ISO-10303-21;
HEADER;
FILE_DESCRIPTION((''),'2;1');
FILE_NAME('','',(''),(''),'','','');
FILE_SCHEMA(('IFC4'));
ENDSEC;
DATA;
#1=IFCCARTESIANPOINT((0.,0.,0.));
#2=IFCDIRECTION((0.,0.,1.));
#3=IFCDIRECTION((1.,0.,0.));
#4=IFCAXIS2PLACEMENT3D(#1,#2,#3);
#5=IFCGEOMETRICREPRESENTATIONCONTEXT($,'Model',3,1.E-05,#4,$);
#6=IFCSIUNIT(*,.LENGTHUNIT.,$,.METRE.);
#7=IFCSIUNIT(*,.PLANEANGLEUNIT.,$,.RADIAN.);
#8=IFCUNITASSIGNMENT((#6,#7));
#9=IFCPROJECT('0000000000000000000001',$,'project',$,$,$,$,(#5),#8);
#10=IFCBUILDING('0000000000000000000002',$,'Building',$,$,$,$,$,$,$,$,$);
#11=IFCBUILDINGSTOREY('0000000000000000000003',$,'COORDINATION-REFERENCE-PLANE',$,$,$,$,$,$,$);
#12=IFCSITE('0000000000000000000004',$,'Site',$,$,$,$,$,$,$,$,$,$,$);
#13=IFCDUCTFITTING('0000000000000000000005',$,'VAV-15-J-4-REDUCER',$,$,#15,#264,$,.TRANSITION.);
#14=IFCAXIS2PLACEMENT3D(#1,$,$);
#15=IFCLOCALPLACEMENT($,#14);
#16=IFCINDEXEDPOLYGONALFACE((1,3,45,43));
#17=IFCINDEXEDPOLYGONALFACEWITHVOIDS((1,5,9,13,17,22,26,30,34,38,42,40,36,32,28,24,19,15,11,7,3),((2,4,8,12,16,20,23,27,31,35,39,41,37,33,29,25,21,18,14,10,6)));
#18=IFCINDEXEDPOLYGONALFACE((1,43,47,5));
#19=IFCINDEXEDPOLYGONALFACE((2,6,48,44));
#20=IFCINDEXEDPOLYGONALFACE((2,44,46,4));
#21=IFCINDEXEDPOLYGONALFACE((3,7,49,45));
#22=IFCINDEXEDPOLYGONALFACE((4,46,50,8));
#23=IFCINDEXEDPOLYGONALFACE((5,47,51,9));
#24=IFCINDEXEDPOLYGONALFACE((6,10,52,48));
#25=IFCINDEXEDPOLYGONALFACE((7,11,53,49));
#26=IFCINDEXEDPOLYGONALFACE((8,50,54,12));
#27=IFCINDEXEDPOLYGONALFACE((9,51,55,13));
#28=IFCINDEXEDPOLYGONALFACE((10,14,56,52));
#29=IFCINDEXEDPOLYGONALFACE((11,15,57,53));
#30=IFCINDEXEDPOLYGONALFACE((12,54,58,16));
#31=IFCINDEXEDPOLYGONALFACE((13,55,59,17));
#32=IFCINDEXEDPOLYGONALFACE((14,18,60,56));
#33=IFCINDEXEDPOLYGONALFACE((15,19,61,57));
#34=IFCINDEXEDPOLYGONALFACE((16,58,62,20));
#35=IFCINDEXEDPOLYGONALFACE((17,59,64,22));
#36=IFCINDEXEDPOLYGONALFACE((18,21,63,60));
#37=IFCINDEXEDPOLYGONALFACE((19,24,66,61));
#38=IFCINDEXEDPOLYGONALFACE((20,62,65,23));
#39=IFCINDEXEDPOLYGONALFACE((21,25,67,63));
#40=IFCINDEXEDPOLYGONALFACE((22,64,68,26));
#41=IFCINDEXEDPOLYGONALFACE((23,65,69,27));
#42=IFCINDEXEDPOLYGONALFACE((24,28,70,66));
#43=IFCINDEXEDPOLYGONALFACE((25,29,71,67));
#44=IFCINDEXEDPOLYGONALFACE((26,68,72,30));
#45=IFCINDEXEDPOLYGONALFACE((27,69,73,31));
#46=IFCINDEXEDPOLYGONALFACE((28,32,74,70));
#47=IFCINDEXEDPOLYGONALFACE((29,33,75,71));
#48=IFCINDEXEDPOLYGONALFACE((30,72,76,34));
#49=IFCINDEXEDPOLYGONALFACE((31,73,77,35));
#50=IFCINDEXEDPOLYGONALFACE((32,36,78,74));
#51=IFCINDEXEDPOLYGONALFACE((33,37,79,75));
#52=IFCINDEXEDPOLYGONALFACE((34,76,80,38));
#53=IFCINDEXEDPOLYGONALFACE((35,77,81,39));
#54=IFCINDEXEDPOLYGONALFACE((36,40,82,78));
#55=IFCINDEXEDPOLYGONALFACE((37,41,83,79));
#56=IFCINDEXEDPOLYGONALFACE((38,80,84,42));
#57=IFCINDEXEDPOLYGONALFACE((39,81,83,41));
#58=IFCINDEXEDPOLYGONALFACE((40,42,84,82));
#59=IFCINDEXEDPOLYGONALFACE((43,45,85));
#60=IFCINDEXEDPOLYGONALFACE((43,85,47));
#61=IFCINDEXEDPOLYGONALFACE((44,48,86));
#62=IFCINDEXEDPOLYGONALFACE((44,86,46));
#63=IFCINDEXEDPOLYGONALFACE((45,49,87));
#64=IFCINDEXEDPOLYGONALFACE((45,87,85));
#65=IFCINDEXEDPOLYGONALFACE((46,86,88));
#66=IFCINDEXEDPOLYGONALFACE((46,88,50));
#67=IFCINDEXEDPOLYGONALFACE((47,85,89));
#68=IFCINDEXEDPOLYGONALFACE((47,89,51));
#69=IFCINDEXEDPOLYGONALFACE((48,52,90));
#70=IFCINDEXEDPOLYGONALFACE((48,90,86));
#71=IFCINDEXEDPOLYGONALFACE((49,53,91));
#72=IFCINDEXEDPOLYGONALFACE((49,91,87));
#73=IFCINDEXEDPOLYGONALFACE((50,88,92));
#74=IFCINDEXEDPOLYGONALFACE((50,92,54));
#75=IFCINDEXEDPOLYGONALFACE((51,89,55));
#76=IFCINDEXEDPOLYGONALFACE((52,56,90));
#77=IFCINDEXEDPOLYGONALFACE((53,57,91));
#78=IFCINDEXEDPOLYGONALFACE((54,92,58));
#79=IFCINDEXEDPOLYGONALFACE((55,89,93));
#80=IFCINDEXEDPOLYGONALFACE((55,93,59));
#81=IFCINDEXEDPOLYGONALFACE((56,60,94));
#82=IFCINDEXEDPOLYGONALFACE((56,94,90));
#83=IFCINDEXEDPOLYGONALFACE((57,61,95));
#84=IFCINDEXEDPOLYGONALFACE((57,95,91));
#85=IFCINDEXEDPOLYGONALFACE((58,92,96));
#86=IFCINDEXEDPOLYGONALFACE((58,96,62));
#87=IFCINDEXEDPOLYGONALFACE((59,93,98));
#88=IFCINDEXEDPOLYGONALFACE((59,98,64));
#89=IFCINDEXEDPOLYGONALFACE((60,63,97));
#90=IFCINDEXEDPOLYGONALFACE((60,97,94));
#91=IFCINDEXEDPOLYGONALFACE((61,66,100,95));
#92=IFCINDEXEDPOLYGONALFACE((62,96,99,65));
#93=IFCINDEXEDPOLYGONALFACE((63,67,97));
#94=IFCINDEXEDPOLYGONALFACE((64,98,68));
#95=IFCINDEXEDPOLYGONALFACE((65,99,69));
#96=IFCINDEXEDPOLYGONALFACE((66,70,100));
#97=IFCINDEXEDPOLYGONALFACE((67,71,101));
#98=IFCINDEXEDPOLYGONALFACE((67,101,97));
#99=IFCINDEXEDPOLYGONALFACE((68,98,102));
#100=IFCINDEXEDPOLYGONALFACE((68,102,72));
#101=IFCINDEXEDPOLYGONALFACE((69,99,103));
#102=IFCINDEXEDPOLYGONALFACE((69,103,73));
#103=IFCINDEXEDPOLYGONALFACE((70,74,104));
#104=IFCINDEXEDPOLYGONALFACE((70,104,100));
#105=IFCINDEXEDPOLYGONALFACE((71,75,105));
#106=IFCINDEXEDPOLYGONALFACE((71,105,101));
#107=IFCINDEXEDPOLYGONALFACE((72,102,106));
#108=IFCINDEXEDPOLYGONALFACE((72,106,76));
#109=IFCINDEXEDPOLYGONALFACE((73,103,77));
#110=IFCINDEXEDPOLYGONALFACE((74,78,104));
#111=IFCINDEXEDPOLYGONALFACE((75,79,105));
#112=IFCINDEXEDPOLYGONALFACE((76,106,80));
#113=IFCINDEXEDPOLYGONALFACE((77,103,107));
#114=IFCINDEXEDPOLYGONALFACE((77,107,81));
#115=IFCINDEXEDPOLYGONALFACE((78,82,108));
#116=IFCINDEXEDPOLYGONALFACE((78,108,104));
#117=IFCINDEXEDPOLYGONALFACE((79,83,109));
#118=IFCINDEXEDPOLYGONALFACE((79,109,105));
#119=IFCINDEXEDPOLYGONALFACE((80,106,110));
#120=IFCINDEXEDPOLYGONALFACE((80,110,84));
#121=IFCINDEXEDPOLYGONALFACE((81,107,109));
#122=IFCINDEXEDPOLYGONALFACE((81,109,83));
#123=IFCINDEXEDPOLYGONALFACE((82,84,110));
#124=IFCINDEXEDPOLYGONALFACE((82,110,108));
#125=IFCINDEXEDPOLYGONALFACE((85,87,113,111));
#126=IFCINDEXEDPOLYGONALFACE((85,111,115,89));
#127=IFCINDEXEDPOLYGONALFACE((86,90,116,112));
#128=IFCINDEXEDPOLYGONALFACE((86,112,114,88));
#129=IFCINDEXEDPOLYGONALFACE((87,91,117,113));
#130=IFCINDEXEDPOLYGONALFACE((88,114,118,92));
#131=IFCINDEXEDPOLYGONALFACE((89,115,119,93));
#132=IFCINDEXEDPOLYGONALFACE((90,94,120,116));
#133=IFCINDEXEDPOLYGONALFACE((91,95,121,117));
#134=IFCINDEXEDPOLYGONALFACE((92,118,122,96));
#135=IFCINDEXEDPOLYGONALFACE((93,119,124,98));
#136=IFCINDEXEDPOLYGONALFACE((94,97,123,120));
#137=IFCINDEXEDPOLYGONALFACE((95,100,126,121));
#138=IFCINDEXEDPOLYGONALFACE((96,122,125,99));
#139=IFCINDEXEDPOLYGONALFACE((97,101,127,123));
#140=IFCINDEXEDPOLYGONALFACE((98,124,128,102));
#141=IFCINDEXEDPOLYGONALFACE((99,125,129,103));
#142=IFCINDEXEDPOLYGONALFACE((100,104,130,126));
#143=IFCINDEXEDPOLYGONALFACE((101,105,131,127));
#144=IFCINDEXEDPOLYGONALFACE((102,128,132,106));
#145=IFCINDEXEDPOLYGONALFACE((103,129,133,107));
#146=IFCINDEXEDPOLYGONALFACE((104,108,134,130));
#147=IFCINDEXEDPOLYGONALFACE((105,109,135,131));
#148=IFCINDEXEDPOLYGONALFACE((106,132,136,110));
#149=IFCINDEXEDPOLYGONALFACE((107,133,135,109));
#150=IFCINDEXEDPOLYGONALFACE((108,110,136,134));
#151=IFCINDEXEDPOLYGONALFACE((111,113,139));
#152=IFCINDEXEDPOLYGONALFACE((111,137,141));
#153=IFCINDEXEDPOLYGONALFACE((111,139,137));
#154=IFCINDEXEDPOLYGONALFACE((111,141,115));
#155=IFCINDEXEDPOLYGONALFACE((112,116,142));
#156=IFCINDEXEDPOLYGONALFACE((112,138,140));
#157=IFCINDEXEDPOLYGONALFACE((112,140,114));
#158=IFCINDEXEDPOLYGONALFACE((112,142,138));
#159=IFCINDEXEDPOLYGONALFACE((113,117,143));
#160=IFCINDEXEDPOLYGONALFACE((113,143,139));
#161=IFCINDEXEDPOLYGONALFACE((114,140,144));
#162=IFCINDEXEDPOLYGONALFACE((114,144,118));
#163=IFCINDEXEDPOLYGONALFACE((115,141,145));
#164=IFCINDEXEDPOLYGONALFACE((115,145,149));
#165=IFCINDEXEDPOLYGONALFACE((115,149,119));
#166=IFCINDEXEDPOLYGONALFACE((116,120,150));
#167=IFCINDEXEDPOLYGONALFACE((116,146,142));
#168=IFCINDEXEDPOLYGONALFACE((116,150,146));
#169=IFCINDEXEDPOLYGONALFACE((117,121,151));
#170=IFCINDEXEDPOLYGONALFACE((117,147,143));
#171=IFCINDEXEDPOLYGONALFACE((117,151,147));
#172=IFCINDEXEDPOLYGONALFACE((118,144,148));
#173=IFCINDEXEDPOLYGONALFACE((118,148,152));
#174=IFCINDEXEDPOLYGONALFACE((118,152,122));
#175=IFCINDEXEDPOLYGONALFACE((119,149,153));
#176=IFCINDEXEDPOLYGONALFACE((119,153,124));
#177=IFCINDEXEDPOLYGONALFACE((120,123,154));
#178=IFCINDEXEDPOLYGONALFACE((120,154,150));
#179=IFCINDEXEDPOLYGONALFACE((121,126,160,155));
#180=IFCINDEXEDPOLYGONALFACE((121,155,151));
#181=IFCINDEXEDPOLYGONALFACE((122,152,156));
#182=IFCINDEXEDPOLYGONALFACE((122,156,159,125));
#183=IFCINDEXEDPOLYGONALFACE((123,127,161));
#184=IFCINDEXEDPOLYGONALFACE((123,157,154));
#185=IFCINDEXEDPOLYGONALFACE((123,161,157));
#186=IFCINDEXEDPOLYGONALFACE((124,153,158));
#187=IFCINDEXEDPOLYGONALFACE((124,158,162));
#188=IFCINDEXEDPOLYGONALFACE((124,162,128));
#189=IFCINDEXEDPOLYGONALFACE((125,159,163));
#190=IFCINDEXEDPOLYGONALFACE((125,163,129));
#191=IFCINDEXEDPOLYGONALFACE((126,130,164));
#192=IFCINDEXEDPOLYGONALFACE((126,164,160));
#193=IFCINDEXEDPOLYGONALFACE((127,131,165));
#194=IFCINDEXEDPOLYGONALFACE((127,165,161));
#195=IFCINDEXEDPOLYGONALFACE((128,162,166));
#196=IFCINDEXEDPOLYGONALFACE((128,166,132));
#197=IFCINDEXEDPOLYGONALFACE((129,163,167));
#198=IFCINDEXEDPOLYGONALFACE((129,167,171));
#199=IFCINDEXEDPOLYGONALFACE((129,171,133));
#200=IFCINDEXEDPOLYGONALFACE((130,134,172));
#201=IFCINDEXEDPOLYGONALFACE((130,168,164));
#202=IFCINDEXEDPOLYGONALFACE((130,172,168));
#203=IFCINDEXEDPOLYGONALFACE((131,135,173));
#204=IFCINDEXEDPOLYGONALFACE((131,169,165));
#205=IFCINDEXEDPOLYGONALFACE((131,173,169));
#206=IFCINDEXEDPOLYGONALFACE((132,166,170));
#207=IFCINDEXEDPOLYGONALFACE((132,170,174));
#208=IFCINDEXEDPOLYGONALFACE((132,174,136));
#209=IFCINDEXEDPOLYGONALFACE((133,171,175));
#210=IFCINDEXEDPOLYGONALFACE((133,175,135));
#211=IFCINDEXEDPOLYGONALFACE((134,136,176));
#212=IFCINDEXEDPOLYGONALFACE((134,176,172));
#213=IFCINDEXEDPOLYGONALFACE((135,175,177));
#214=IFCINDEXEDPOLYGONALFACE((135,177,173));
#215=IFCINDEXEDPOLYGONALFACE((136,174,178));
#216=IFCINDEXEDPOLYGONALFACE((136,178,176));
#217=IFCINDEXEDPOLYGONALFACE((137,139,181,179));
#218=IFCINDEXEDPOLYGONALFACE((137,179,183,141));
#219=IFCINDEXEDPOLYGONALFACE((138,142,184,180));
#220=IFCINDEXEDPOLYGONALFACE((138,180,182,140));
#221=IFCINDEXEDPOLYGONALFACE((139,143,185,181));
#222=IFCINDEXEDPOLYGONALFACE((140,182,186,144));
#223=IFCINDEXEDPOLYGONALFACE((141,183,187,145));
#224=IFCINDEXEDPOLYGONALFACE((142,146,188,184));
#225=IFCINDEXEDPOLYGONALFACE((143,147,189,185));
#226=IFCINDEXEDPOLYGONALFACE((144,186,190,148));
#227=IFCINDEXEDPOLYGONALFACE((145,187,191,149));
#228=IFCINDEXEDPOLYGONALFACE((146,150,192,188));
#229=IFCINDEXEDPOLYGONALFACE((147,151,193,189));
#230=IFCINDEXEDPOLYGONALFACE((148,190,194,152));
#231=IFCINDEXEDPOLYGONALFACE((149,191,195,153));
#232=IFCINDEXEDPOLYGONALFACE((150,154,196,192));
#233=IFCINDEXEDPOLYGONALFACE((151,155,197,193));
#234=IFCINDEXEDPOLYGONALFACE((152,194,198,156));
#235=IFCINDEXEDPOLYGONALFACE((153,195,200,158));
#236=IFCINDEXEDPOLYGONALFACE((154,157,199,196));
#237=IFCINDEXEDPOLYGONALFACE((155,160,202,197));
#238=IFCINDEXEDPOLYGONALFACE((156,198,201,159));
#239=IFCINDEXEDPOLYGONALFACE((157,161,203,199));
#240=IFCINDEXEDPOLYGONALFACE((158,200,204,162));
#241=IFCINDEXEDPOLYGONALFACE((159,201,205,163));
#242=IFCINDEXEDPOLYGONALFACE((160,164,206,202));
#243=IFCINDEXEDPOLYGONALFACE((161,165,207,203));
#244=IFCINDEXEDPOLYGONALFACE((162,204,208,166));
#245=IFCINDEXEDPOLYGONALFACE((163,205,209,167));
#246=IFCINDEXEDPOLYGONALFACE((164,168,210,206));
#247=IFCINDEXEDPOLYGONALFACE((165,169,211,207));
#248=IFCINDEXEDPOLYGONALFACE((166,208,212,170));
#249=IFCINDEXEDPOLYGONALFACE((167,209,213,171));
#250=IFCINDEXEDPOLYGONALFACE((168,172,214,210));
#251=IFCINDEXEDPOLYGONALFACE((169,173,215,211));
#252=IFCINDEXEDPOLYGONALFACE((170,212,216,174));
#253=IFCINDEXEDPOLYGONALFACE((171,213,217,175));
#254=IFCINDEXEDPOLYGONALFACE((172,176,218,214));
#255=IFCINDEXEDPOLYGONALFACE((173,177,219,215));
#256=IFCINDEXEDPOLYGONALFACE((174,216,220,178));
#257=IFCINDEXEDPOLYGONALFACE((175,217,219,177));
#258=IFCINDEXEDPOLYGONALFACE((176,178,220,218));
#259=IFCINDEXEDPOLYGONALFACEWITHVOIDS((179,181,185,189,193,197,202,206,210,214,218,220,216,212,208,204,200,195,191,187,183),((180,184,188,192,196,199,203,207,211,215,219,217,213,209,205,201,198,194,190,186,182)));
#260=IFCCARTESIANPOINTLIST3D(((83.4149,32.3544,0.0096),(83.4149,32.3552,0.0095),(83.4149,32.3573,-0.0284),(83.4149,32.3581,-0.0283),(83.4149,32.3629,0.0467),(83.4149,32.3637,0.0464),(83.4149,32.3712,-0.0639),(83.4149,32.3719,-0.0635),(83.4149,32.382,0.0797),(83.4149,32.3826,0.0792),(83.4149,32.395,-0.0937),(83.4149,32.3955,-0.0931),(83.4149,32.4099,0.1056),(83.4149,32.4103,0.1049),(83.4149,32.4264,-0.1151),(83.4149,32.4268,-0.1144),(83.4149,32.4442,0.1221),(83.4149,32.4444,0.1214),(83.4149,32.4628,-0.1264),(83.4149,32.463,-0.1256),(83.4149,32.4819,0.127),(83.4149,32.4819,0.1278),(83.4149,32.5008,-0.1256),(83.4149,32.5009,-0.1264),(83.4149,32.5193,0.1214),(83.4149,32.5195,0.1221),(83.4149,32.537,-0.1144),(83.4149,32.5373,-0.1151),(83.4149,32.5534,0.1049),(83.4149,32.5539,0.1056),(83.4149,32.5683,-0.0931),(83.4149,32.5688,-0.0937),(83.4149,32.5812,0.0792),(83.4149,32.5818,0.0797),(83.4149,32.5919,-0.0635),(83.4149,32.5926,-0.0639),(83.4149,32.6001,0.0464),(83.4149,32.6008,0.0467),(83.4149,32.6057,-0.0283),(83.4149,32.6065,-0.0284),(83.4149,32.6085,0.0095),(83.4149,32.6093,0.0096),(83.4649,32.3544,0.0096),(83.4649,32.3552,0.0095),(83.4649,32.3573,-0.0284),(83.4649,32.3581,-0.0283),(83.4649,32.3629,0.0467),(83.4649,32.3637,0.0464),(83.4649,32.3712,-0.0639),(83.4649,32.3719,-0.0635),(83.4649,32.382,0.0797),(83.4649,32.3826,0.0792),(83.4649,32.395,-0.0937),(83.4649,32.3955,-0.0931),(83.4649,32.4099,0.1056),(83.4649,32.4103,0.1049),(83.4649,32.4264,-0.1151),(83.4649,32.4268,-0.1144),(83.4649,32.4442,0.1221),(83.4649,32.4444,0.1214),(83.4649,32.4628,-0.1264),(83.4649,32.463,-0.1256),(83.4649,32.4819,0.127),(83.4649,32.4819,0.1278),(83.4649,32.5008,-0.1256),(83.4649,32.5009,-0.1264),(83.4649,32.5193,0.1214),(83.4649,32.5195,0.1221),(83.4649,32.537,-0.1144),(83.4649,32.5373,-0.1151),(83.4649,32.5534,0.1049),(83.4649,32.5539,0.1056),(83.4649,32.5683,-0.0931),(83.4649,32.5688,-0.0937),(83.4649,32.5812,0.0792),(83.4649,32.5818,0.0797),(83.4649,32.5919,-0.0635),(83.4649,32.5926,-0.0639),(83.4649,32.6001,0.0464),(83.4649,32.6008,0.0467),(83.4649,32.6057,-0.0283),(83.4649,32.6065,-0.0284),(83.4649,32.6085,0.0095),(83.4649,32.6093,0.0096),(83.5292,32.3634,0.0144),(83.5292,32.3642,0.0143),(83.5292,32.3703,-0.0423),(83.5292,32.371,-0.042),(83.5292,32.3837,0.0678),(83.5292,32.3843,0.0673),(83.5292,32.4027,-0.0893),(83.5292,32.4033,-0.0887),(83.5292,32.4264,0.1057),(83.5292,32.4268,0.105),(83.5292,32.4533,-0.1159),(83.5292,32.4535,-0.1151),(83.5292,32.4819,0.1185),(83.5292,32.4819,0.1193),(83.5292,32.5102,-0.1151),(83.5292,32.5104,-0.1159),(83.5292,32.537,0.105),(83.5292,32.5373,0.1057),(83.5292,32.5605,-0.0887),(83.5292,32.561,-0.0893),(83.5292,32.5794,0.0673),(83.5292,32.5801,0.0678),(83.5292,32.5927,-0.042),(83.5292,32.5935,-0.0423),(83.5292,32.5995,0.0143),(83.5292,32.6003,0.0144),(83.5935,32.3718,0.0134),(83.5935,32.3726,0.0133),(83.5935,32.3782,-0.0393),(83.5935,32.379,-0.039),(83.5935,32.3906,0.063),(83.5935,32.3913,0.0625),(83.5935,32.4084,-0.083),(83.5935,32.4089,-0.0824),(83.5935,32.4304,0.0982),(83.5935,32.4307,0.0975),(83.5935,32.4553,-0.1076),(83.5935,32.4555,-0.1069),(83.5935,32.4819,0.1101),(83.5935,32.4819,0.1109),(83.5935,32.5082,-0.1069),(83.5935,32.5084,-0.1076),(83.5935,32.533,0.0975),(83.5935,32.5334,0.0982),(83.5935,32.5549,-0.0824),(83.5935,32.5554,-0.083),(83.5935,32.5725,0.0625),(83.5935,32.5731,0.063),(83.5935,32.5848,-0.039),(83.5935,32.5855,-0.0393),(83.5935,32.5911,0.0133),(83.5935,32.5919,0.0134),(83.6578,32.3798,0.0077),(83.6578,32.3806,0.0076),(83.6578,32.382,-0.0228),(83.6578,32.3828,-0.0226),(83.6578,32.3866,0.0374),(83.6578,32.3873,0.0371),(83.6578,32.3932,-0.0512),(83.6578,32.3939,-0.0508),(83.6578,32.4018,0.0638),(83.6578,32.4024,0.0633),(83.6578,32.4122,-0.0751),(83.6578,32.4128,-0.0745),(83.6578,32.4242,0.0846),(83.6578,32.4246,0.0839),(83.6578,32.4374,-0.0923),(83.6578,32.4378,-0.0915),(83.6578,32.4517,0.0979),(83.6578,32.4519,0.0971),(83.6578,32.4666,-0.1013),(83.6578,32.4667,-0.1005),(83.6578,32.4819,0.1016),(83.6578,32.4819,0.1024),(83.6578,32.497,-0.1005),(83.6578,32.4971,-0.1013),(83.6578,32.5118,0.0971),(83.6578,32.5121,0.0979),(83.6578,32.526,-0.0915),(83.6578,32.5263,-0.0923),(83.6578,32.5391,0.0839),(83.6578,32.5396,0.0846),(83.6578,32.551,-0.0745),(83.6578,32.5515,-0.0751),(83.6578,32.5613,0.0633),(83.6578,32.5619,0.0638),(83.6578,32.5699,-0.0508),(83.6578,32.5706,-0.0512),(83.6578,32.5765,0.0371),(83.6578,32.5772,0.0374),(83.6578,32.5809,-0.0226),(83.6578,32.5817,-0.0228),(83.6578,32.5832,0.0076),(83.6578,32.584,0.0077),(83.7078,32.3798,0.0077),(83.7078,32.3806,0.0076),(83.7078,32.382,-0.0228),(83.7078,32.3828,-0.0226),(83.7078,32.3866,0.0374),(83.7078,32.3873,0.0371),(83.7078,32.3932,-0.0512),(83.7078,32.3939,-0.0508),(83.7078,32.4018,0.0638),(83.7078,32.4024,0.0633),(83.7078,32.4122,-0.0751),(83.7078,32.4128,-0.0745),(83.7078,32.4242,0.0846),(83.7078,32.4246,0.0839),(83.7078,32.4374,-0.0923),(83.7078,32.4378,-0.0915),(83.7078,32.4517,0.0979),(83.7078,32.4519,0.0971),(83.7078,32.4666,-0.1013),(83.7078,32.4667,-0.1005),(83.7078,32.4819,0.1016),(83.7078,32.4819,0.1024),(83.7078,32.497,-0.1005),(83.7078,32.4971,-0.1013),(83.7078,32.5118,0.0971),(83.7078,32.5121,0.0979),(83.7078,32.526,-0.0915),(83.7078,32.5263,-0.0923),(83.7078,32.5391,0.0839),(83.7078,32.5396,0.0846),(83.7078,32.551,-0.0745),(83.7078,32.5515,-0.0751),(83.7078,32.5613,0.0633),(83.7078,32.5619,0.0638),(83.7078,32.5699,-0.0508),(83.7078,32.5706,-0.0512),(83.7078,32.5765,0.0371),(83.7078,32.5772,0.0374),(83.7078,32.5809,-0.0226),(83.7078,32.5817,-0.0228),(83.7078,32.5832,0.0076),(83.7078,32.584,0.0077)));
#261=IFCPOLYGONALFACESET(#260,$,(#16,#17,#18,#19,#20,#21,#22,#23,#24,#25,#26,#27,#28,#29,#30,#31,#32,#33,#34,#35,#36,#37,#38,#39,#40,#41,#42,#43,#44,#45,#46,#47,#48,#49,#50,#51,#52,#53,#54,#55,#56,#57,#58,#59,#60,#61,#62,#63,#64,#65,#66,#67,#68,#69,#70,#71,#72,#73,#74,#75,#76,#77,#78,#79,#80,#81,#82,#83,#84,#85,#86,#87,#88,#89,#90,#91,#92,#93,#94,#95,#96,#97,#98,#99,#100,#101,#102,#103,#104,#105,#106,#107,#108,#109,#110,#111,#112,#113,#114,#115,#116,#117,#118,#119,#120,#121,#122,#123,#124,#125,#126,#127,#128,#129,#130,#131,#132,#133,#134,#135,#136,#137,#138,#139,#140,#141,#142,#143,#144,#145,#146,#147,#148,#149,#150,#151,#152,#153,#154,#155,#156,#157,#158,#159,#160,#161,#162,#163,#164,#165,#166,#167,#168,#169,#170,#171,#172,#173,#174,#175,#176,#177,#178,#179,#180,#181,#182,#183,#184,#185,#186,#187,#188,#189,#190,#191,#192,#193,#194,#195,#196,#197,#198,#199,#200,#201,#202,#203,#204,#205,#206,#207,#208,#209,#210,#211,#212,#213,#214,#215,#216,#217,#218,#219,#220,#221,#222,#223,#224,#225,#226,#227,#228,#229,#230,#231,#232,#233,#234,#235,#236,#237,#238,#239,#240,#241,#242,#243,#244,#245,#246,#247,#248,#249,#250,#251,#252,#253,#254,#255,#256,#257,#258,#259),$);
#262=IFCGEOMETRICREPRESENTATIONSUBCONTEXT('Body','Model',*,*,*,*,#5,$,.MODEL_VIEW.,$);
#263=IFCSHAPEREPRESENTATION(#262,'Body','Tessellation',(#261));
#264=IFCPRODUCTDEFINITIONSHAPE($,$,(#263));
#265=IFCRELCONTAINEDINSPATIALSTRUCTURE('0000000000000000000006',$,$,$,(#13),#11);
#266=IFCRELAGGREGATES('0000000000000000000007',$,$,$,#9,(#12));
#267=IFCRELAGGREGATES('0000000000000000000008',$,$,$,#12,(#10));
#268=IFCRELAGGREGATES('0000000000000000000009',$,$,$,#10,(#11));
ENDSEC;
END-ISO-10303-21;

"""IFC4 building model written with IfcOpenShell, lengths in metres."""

from ifc_helpers import new_model, entity, si_unit, frame, origin_with_axes, place, context, subcontext, project, spatial, element, save


model = new_model("IFC4")

# Units and contexts
model_context = context("Model", 3, precision=1e-05, world=origin_with_axes())
body_context_1 = subcontext(model_context, "Body", "Model", "MODEL_VIEW")
ifc_project = project(units=[si_unit("LENGTHUNIT", "METRE"), si_unit("PLANEANGLEUNIT", "RADIAN")], contexts=[model_context])

# Site, building, storey
site = spatial("IfcSite", under=ifc_project, Name="Site")
building = spatial("IfcBuilding", under=site, Name="Building")
storey = spatial("IfcBuildingStorey", under=building, Name="COORDINATION-REFERENCE-PLANE")

# Duct fitting
for number, where, z_axis, x_axis, name in (
    (1, (83.4149, 32.4819, 0.0), (0.0, 1.0, 0.0), (0.0, 0.0, 1.0), "VAV-15-J-4-REDUCER"),
):
    element("IfcDuctFitting", number, at=place(None, frame(where, z_axis=z_axis, x_axis=x_axis)), inside=storey, Name=name, PredefinedType="TRANSITION", context=body_context_1, shape_type="SweptSolid", body=[
        entity("IfcRevolvedAreaSolid", entity("IfcArbitraryClosedProfileDef", "AREA", None, entity("IfcPolyline", [entity("IfcCartesianPoint", [0.1278, 0.0]), entity("IfcCartesianPoint", [0.1278, 0.05]), entity("IfcCartesianPoint", [0.1024, 0.2429]), entity("IfcCartesianPoint", [0.1024, 0.2929]), entity("IfcCartesianPoint", [0.1016, 0.2929]), entity("IfcCartesianPoint", [0.1016, 0.2429]), entity("IfcCartesianPoint", [0.127, 0.05]), entity("IfcCartesianPoint", [0.127, 0.0]), entity("IfcCartesianPoint", [0.1278, 0.0])])), entity("IfcAxis2Placement3D", entity("IfcCartesianPoint", [0.0, 0.0, 0.0])), entity("IfcAxis1Placement", entity("IfcCartesianPoint", [0.0, 0.0, 0.0]), entity("IfcDirection", [0.0, 1.0, 0.0])), 6.283185),
    ])

save(model, "model.ifc")
